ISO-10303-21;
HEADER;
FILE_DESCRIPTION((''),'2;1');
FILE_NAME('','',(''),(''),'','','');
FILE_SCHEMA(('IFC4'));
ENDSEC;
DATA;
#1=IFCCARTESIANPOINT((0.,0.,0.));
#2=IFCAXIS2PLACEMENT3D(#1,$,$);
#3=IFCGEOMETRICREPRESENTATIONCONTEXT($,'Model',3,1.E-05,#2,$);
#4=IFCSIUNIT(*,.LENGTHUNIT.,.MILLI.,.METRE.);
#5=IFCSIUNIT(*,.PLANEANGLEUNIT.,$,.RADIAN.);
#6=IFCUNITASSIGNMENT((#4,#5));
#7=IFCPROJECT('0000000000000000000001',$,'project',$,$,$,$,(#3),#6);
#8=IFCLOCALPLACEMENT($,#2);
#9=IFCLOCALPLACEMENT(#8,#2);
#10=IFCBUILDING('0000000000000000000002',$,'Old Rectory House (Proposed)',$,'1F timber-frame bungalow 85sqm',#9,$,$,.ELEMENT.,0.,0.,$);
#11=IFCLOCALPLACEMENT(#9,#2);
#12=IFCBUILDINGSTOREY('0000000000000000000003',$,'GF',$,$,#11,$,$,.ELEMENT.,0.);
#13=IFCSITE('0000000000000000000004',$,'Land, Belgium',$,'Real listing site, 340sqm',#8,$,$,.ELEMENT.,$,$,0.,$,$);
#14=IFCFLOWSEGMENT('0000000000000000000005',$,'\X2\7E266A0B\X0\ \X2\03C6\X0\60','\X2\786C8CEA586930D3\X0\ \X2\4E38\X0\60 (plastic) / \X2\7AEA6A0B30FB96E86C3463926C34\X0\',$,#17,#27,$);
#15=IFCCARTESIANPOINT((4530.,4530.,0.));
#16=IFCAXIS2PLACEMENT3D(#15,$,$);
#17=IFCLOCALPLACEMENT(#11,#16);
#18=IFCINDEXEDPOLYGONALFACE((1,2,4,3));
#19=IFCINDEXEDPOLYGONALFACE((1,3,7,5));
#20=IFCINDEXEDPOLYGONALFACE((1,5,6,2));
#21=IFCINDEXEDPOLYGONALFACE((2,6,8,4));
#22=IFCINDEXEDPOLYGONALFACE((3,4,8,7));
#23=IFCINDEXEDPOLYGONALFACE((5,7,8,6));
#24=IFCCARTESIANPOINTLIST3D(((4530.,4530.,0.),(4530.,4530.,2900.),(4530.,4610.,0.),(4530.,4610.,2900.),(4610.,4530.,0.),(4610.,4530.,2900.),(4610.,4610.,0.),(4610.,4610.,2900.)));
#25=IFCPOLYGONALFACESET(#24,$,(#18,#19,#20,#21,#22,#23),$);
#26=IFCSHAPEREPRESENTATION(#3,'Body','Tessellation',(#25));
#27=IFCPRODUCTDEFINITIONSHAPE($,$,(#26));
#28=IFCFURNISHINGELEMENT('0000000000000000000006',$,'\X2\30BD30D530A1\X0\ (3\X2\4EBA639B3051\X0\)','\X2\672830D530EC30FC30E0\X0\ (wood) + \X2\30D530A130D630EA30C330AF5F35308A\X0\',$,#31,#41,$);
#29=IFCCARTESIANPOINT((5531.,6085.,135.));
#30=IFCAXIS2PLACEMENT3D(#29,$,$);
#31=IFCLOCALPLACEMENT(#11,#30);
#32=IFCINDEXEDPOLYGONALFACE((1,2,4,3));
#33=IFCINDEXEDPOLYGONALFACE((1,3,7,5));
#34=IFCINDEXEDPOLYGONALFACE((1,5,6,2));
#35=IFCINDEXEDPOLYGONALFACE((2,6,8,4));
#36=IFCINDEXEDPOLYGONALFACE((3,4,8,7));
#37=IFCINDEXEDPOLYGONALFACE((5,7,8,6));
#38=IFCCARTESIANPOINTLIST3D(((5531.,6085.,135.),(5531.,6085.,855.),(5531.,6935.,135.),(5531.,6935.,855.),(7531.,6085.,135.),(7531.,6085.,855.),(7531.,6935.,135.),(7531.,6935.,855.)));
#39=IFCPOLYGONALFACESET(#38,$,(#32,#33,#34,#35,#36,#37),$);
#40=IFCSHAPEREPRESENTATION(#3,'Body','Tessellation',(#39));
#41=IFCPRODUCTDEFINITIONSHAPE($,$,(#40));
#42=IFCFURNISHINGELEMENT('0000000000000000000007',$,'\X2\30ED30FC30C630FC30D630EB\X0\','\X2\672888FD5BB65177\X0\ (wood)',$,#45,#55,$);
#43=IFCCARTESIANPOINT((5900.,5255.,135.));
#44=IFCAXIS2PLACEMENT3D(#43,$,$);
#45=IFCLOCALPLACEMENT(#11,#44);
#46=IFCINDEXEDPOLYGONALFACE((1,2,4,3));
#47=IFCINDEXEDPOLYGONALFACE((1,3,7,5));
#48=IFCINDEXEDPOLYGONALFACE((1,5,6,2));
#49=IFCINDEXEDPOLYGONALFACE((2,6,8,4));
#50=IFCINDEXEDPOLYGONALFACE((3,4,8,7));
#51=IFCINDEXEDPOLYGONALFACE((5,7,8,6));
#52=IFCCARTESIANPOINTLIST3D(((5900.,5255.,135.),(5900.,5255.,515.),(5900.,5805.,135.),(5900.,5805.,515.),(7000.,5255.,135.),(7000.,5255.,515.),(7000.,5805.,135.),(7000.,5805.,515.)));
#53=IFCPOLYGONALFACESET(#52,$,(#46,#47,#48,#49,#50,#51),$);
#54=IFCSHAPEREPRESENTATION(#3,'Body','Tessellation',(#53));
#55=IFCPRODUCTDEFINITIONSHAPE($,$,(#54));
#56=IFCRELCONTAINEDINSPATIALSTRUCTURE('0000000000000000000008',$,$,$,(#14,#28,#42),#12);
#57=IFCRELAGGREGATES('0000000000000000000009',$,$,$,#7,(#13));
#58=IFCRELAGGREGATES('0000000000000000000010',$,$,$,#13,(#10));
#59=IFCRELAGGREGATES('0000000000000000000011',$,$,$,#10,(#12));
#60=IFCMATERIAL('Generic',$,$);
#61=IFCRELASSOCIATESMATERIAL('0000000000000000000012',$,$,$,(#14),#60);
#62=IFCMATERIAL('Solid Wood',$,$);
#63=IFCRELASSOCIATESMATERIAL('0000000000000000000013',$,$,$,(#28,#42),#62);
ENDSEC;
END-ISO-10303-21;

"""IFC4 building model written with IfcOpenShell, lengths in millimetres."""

from ifc_helpers import new_model, si_unit, frame, frame_2d, origin, place, context, project, spatial, rectangle, extrude, material, element, save


model = new_model("IFC4")

# Units and contexts
model_context = context("Model", 3, precision=1e-05, world=origin())
ifc_project = project(units=[si_unit("LENGTHUNIT", "METRE", prefix="MILLI"), si_unit("PLANEANGLEUNIT", "RADIAN")], contexts=[model_context])

# Site, building, storey
site_placement = place(None, origin())
site = spatial("IfcSite", under=ifc_project, at=site_placement, Name="Land, Belgium", ObjectType="Real listing site, 340sqm", CompositionType="ELEMENT", RefElevation=0.0)
building_placement = place(site_placement, origin())
building = spatial("IfcBuilding", under=site, at=building_placement, Name="Old Rectory House (Proposed)", ObjectType="1F timber-frame bungalow 85sqm", CompositionType="ELEMENT", ElevationOfRefHeight=0.0, ElevationOfTerrain=0.0)
storey_placement = place(building_placement, origin())
storey = spatial("IfcBuildingStorey", under=building, at=storey_placement, Name="GF", CompositionType="ELEMENT", Elevation=0.0)

# Shared definitions
ifc_material_1 = material(Name="Solid Wood")

# Shared definitions
ifc_material_2 = material(Name="Generic")

# Flow segment
flow_segment_1_placement = place(storey_placement, frame((4530.0, 4530.0, 0.0)))
element("IfcFlowSegment", 1, at=flow_segment_1_placement, inside=storey, material=ifc_material_2, Name="縦樋 φ60", Description="硬質塩ビ 丸60 (plastic) / 竪樋・雨水排水", context=model_context, shape_type="SweptSolid", body=[
    extrude(rectangle(XDim=80.0, YDim=80.0, at=frame_2d((40.0, 40.0))), frame((4530.0, 4530.0, 0.0)), (0.0, 0.0, 1.0), 2900.0),
])

# Furnishing elements
furnishing_1_placement = place(storey_placement, frame((5531.0, 6085.0, 135.0)))
element("IfcFurnishingElement", 2, at=furnishing_1_placement, inside=storey, material=ifc_material_1, Name="ソファ (3人掛け)", Description="木フレーム (wood) + ファブリック張り", context=model_context, shape_type="SweptSolid", body=[
    extrude(rectangle(XDim=2000.0, YDim=850.0, at=frame_2d((1000.0, 425.0))), frame((5531.0, 6085.0, 135.0)), (0.0, 0.0, 1.0), 720.0),
])
furnishing_2_placement = place(storey_placement, frame((5900.0, 5255.0, 135.0)))
element("IfcFurnishingElement", 3, at=furnishing_2_placement, inside=storey, material=ifc_material_1, Name="ローテーブル", Description="木製家具 (wood)", context=model_context, shape_type="SweptSolid", body=[
    extrude(rectangle(XDim=1100.0, YDim=550.0, at=frame_2d((550.0, 275.0))), frame((5900.0, 5255.0, 135.0)), (0.0, 0.0, 1.0), 380.0),
])

save(model, "model.ifc")
